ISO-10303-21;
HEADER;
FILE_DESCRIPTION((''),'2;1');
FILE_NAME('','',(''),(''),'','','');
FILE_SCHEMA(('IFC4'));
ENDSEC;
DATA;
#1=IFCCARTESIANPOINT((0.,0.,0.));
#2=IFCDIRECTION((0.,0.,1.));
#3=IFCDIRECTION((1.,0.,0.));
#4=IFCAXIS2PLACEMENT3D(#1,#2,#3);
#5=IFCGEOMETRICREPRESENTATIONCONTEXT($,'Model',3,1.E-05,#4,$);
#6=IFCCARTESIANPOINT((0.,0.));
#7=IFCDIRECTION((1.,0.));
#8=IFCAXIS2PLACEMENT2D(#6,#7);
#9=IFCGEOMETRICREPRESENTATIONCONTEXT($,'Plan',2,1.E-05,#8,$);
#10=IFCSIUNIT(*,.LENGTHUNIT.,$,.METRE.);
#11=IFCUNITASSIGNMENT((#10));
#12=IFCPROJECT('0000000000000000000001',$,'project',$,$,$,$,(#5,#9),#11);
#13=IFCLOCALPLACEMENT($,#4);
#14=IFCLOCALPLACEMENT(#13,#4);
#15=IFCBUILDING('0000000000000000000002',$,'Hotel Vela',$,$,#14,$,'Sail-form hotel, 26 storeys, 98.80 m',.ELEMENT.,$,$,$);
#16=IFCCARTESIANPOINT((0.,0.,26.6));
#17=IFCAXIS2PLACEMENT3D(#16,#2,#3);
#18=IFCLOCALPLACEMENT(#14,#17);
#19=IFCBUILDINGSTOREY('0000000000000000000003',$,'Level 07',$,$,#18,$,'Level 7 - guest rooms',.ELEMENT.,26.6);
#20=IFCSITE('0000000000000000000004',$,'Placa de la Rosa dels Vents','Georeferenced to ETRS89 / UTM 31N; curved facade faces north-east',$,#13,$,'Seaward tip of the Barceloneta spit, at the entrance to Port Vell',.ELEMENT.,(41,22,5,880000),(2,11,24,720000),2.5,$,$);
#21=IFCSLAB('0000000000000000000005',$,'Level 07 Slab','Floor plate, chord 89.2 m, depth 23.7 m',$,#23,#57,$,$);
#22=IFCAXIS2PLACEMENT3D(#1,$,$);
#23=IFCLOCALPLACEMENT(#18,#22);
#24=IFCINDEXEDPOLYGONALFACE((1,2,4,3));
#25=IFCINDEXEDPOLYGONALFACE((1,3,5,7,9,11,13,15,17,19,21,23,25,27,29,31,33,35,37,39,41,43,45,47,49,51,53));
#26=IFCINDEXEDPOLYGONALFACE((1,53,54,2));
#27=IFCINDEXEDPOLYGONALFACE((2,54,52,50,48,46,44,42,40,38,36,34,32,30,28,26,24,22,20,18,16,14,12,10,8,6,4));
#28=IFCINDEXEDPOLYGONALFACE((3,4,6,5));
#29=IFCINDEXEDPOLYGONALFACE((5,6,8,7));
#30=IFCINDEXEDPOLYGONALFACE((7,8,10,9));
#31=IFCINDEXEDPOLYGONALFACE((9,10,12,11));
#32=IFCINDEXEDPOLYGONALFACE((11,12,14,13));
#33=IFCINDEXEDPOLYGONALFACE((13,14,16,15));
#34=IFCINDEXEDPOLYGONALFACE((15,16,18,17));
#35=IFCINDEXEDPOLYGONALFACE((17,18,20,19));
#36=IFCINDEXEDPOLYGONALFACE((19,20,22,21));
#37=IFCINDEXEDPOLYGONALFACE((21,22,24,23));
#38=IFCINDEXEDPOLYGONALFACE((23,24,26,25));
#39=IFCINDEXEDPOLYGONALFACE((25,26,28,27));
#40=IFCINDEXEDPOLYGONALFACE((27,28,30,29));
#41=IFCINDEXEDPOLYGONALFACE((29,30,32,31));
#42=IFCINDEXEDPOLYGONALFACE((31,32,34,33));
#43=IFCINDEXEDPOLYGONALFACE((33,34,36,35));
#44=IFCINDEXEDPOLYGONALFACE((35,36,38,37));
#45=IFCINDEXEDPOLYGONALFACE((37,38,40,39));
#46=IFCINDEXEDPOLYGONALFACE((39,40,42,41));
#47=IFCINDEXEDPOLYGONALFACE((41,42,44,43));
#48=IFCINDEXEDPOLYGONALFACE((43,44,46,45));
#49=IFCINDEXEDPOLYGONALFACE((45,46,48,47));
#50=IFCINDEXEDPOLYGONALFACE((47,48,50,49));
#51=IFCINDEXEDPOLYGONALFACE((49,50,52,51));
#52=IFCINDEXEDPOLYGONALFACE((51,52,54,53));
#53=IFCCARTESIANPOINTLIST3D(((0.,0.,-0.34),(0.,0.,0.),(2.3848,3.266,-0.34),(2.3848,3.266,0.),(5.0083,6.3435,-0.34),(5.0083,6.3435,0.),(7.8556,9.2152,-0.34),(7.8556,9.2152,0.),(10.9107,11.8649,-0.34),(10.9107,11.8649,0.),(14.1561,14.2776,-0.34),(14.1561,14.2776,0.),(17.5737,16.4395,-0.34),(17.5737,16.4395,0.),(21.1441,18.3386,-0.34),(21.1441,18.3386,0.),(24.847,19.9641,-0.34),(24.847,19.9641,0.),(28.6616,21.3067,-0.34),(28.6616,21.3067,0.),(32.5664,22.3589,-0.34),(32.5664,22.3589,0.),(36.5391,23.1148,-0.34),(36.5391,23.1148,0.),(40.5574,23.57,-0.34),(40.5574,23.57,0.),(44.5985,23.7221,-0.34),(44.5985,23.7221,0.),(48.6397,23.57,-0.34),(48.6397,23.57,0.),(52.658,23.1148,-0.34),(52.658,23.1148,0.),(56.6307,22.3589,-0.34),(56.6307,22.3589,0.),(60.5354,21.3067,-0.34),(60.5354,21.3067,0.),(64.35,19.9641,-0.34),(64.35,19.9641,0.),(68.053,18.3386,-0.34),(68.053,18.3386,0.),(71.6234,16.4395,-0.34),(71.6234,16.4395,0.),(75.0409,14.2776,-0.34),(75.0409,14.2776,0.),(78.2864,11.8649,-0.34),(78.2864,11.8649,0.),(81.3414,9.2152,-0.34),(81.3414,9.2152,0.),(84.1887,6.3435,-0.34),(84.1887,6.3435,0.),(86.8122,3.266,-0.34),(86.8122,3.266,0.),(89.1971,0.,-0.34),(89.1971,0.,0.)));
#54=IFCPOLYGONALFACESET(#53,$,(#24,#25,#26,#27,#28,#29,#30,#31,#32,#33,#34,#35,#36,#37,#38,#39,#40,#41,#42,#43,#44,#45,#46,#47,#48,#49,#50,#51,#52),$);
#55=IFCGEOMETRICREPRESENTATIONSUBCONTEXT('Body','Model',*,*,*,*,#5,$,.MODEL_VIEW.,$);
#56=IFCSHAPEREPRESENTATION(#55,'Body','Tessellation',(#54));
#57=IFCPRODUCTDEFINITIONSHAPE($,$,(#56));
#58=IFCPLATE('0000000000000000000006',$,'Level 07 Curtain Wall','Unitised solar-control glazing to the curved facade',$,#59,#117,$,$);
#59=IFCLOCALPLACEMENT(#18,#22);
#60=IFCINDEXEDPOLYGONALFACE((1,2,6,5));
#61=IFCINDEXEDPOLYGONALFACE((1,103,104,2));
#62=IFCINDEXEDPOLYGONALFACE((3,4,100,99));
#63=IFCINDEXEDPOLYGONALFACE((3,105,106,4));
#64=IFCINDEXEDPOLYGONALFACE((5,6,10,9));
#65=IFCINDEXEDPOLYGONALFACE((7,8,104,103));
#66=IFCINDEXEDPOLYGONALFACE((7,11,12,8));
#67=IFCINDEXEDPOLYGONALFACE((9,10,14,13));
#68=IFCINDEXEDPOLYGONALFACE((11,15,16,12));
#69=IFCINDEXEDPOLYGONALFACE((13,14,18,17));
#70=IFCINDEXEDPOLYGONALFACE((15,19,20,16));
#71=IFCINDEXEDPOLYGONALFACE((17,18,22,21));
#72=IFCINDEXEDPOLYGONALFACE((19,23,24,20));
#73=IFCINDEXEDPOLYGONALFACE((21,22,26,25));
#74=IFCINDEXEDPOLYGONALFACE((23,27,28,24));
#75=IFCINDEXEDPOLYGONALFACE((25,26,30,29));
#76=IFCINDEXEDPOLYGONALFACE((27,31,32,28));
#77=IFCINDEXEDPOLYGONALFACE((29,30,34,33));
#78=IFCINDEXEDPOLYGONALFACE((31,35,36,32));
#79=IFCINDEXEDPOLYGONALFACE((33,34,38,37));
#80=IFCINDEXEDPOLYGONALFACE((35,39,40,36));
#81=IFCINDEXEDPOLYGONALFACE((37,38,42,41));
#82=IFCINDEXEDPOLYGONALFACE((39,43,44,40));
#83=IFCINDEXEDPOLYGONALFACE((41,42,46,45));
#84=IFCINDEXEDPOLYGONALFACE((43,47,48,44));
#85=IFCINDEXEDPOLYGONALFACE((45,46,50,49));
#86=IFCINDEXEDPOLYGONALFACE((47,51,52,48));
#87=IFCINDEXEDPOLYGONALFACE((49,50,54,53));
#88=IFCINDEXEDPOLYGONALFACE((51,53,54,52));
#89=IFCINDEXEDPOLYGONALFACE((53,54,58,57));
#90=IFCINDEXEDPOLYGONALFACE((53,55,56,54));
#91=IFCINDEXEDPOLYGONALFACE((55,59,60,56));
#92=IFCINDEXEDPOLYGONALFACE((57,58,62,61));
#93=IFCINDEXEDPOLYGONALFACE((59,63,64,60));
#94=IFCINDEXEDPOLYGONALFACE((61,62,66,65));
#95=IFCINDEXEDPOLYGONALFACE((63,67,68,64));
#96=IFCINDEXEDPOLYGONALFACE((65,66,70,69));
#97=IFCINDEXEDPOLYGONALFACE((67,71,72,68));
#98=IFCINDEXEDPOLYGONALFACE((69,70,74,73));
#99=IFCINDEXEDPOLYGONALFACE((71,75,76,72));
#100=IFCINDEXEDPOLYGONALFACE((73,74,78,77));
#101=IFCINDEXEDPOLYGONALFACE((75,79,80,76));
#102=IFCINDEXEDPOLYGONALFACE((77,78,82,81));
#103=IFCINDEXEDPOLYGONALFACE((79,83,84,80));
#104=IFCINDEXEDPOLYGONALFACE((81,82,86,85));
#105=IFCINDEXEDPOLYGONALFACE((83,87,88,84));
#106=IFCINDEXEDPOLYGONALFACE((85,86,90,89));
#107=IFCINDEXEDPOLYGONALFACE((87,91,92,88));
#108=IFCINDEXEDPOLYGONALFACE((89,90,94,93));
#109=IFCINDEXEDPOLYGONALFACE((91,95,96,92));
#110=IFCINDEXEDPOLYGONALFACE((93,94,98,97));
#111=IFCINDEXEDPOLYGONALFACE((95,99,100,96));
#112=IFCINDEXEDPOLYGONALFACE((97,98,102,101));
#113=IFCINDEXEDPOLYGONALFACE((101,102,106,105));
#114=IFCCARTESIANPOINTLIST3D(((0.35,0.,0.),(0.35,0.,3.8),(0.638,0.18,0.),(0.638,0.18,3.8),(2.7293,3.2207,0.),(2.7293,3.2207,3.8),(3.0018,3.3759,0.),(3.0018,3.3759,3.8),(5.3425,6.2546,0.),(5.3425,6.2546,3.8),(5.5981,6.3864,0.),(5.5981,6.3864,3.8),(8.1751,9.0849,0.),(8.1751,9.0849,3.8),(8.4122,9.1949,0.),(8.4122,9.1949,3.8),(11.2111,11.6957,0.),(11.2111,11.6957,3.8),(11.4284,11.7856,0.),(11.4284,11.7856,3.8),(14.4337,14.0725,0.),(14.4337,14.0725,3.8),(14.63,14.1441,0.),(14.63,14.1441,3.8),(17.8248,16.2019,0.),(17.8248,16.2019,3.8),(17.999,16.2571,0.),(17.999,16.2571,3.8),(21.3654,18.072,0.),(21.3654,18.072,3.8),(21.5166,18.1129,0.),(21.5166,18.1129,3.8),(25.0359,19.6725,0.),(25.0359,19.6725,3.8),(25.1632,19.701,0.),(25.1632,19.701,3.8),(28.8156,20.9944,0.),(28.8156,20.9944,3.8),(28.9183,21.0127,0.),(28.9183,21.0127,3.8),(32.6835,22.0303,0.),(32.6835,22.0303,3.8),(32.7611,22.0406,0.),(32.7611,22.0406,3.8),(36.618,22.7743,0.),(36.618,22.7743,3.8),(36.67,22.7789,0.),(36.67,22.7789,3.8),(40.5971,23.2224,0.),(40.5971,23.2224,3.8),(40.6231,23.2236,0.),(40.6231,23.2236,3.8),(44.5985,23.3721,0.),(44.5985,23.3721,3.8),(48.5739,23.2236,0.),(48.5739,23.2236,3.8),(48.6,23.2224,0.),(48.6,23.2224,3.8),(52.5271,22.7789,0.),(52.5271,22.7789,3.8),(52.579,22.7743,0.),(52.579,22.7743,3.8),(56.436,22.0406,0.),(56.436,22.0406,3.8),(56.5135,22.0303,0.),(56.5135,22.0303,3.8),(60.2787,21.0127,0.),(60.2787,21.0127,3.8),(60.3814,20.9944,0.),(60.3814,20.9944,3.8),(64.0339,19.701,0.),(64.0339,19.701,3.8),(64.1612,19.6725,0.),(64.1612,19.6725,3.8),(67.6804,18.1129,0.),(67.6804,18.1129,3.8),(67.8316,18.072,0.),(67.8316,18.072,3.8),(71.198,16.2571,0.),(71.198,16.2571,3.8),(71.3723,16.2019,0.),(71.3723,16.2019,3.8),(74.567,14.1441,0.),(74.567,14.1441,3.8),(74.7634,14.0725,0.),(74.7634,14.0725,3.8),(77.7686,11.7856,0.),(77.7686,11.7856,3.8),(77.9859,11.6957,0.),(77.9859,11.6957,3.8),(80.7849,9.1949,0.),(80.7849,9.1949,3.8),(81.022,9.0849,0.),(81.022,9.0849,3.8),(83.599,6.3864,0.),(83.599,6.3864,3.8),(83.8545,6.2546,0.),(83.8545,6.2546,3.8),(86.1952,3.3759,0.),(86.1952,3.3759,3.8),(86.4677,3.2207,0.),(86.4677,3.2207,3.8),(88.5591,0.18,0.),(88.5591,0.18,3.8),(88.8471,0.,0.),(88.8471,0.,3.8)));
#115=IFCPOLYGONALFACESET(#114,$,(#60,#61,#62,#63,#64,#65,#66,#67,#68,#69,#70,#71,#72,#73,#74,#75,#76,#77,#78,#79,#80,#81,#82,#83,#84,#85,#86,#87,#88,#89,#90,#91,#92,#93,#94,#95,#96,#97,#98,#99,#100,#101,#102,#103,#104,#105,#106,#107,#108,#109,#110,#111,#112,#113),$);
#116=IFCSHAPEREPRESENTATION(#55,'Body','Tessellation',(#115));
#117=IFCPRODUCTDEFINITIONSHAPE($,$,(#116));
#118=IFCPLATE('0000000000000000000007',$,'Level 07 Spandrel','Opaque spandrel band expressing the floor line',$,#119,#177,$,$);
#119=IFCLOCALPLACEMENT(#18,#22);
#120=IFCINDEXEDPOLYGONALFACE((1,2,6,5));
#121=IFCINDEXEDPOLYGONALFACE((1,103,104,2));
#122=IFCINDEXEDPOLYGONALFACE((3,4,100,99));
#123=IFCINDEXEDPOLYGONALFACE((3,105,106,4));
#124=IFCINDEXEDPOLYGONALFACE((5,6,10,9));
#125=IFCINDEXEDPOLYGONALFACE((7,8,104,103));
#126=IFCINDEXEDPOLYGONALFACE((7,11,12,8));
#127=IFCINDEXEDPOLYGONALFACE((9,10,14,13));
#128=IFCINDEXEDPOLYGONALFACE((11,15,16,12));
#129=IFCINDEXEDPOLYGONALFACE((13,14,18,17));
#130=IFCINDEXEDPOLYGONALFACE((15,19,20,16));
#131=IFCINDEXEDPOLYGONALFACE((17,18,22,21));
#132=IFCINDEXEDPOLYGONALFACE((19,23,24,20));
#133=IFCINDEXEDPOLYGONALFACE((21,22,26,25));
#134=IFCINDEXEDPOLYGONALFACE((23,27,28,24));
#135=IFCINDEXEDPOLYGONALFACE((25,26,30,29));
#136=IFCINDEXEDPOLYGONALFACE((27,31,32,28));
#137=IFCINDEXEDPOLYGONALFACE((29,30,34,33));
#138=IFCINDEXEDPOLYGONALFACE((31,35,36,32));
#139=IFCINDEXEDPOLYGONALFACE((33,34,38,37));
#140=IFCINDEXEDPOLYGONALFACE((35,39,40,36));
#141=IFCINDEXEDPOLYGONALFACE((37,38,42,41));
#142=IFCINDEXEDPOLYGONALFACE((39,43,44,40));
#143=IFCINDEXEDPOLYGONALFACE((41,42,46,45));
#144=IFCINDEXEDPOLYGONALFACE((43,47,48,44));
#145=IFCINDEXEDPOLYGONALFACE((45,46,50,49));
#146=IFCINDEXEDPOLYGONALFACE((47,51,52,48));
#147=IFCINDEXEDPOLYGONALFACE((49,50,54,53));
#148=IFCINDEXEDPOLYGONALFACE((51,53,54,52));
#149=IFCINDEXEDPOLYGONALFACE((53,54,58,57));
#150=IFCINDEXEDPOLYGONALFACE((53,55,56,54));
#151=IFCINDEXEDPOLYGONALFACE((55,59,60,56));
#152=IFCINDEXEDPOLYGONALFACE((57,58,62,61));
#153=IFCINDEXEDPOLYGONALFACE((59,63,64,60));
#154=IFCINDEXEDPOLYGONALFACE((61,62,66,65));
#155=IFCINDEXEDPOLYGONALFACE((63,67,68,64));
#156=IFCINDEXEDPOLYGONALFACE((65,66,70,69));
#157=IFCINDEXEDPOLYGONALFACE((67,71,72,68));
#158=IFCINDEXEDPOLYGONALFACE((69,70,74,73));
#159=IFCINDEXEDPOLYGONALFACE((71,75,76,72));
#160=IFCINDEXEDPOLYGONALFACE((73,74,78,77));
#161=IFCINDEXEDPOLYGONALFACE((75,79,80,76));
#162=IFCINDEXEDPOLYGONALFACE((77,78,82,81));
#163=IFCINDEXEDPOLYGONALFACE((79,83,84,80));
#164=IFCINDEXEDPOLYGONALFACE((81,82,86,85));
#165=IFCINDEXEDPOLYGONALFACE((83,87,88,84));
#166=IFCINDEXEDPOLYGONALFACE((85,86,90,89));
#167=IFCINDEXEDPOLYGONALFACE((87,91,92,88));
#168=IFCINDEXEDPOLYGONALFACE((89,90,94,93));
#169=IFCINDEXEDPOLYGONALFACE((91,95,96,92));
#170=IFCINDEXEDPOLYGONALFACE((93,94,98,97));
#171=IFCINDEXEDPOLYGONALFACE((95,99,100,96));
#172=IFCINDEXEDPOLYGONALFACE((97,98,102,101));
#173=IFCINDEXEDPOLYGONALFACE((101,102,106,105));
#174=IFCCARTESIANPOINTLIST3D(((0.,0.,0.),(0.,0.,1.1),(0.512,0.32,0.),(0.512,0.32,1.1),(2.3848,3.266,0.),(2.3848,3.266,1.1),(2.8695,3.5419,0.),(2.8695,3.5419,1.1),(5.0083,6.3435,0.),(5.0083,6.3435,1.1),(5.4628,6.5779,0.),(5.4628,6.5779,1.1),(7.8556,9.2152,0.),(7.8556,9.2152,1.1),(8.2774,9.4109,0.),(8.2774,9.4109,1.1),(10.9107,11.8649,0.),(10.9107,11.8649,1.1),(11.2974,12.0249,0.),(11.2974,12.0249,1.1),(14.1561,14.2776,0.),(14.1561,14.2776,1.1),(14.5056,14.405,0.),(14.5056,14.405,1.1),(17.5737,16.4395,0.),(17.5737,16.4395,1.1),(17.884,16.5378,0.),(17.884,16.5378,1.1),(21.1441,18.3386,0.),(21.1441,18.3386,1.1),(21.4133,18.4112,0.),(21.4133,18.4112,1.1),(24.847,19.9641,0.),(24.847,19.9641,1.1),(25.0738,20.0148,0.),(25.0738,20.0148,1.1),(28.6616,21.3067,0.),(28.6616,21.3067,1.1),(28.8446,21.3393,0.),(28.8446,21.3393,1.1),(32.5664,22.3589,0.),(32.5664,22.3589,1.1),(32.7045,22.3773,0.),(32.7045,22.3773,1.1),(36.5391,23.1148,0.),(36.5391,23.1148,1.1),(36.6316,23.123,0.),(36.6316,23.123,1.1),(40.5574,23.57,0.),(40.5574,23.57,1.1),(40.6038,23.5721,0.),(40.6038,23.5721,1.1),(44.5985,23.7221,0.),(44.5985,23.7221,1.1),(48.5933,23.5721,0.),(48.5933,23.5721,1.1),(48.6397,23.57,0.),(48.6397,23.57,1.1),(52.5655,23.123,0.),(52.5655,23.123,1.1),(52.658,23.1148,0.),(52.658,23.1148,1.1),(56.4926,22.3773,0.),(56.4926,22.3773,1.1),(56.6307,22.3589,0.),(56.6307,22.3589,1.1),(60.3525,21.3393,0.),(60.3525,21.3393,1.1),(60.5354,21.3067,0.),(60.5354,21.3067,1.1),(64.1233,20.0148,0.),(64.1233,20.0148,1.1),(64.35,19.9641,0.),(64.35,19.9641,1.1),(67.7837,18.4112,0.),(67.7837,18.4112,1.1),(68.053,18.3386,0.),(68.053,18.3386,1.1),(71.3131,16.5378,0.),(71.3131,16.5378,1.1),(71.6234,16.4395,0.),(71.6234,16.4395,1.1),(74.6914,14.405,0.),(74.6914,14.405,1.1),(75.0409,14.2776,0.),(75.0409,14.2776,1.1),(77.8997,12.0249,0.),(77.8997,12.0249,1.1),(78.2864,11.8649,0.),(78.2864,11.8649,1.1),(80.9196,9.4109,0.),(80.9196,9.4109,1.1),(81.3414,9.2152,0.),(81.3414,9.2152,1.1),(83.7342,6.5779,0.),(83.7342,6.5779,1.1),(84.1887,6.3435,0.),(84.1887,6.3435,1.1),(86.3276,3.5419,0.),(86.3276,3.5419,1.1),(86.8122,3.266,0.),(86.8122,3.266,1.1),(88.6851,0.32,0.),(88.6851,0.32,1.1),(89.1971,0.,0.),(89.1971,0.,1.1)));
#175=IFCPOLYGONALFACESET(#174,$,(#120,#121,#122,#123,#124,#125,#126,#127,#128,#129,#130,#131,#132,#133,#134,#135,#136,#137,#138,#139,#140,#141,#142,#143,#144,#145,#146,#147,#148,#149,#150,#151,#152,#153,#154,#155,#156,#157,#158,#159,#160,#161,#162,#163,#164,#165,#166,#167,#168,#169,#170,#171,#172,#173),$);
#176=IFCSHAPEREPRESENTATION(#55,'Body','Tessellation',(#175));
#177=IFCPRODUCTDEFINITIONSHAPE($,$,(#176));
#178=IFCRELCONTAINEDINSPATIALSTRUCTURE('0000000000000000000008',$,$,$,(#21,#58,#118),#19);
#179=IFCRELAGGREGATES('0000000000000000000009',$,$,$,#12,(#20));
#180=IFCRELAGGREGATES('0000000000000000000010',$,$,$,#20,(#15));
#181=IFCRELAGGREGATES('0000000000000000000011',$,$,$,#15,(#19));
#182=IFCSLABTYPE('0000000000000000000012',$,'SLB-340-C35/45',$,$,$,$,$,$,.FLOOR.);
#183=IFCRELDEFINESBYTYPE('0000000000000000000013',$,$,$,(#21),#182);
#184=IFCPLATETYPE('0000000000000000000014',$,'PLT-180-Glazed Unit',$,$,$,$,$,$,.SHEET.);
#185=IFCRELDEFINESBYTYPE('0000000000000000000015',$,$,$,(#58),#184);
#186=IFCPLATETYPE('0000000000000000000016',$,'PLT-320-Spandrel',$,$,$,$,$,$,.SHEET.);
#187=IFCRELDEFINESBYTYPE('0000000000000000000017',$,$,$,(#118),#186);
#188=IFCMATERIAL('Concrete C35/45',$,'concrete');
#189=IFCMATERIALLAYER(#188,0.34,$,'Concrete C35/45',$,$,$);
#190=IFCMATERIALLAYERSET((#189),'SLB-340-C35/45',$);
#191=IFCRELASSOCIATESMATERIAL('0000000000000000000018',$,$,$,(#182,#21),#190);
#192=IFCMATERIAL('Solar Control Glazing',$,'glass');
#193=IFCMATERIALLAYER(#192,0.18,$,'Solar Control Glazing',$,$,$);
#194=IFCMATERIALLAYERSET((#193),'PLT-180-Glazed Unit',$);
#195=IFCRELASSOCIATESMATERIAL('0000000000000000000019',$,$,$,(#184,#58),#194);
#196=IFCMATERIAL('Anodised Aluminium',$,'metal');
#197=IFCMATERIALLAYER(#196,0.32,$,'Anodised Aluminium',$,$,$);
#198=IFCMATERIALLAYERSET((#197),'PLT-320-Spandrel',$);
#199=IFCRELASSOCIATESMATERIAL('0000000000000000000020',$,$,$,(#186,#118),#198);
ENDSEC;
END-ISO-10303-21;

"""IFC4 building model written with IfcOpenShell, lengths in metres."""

from ifc_helpers import new_model, si_unit, frame, origin_with_axes, origin_2d_with_axis, place, context, subcontext, project, spatial, line, indexed_curve, outline, extrude, material, layer, layer_set, layer_usage, type_object, element, save


model = new_model("IFC4")

# Units and contexts
model_context = context("Model", 3, precision=1e-05, world=origin_with_axes())
plan_context = context("Plan", 2, precision=1e-05, world=origin_2d_with_axis())
body_context = subcontext(model_context, "Body", "Model", "MODEL_VIEW")
ifc_project = project(units=[si_unit("LENGTHUNIT", "METRE")], contexts=[model_context, plan_context])

# Site, building, storey
site_placement = place(None, origin_with_axes())
site = spatial("IfcSite", under=ifc_project, at=site_placement, Name="Placa de la Rosa dels Vents", Description="Georeferenced to ETRS89 / UTM 31N; curved facade faces north-east", LongName="Seaward tip of the Barceloneta spit, at the entrance to Port Vell", CompositionType="ELEMENT", RefLatitude=(41, 22, 5, 880000), RefLongitude=(2, 11, 24, 720000), RefElevation=2.5)
building_placement = place(site_placement, origin_with_axes())
building = spatial("IfcBuilding", under=site, at=building_placement, Name="Hotel Vela", LongName="Sail-form hotel, 26 storeys, 98.80 m", CompositionType="ELEMENT")
storey_placement = place(building_placement, frame((0.0, 0.0, 26.6), z_axis=(0.0, 0.0, 1.0), x_axis=(1.0, 0.0, 0.0)))
storey = spatial("IfcBuildingStorey", under=building, at=storey_placement, Name="Level 07", LongName="Level 7 - guest rooms", CompositionType="ELEMENT", Elevation=26.6)

# Slab
ifc_material_1 = material(Name="Concrete C35/45", Category="concrete")
ifc_layer_1 = layer(ifc_material_1, 0.34, Name="Concrete C35/45")
ifc_layer_set_1 = layer_set([ifc_layer_1], Name="SLB-340-C35/45")
ifc_layer_usage_1 = layer_usage(ifc_layer_set_1, "AXIS3", "POSITIVE", 0.0)
slab_type = type_object("IfcSlabType", Name="SLB-340-C35/45", PredefinedType="FLOOR", material=ifc_layer_set_1)
slab_placement = place(storey_placement, frame((0.0, 0.0, -0.34), z_axis=(0.0, 0.0, 1.0), x_axis=(1.0, 0.0, 0.0)))
element("IfcSlab", 1, at=slab_placement, inside=storey, type_object=slab_type, material=ifc_layer_usage_1, Name="Level 07 Slab", Description="Floor plate, chord 89.2 m, depth 23.7 m", context=body_context, shape_type="SweptSolid", body=[
    extrude(outline(indexed_curve([(0.0, 0.0), (89.1971, 0.0), (86.8122, 3.266), (84.1887, 6.3435), (81.3414, 9.2152), (78.2864, 11.8649), (75.0409, 14.2776), (71.6234, 16.4395), (68.053, 18.3386), (64.35, 19.9641), (60.5354, 21.3067), (56.6307, 22.3589), (52.658, 23.1148), (48.6397, 23.57), (44.5985, 23.7221), (40.5574, 23.57), (36.5391, 23.1148), (32.5664, 22.3589), (28.6616, 21.3067), (24.847, 19.9641), (21.1441, 18.3386), (17.5737, 16.4395), (14.1561, 14.2776), (10.9107, 11.8649), (7.8556, 9.2152), (5.0083, 6.3435), (2.3848, 3.266)], segments=[line(1, 2, 3, 4, 5, 6, 7, 8, 9, 10, 11, 12, 13, 14, 15, 16, 17, 18, 19, 20, 21, 22, 23, 24, 25, 26, 27, 1)])), origin_with_axes(), (0.0, 0.0, 1.0), 0.34),
])

# Plates
ifc_material_2 = material(Name="Solar Control Glazing", Category="glass")
ifc_layer_2 = layer(ifc_material_2, 0.18, Name="Solar Control Glazing")
ifc_layer_set_2 = layer_set([ifc_layer_2], Name="PLT-180-Glazed Unit")
ifc_layer_usage_2 = layer_usage(ifc_layer_set_2, "AXIS2", "POSITIVE", 0.0)
plate_type_1 = type_object("IfcPlateType", Name="PLT-180-Glazed Unit", PredefinedType="SHEET", material=ifc_layer_set_2)
plate_1_placement = place(storey_placement, frame((0.35, 0.0, 0.0), z_axis=(0.0, 0.0, 1.0), x_axis=(1.0, 0.0, 0.0)))
element("IfcPlate", 2, at=plate_1_placement, inside=storey, type_object=plate_type_1, material=ifc_layer_usage_2, Name="Level 07 Curtain Wall", Description="Unitised solar-control glazing to the curved facade", context=body_context, shape_type="SweptSolid", body=[
    extrude(outline(indexed_curve([(88.4971, 0.0), (86.1177, 3.2207), (83.5045, 6.2546), (80.672, 9.0849), (77.6359, 11.6957), (74.4134, 14.0725), (71.0223, 16.2019), (67.4816, 18.072), (63.8112, 19.6725), (60.0314, 20.9944), (56.1635, 22.0303), (52.229, 22.7743), (48.25, 23.2224), (44.2485, 23.3721), (40.2471, 23.2224), (36.268, 22.7743), (32.3335, 22.0303), (28.4656, 20.9944), (24.6859, 19.6725), (21.0154, 18.072), (17.4748, 16.2019), (14.0837, 14.0725), (10.8611, 11.6957), (7.8251, 9.0849), (4.9925, 6.2546), (2.3793, 3.2207), (0.0, 0.0), (88.2091, 0.18), (2.6518, 3.3759), (5.2481, 6.3864), (8.0622, 9.1949), (11.0784, 11.7856), (14.28, 14.1441), (17.649, 16.2571), (21.1666, 18.1129), (24.8132, 19.701), (28.5683, 21.0127), (32.4111, 22.0406), (36.32, 22.7789), (40.2731, 23.2236), (44.2485, 23.3721), (48.2239, 23.2236), (52.1771, 22.7789), (56.086, 22.0406), (59.9287, 21.0127), (63.6839, 19.701), (67.3304, 18.1129), (70.848, 16.2571), (74.217, 14.1441), (77.4186, 11.7856), (80.4349, 9.1949), (83.249, 6.3864), (85.8452, 3.3759), (0.288, 0.18)], segments=[line(1, 2, 3, 4, 5, 6, 7, 8, 9, 10, 11, 12, 13, 14, 15, 16, 17, 18, 19, 20, 21, 22, 23, 24, 25, 26, 27, 28, 29, 30, 31, 32, 33, 34, 35, 36, 37, 38, 39, 40, 41, 42, 43, 44, 45, 46, 47, 48, 49, 50, 51, 52, 53, 54, 1)])), origin_with_axes(), (0.0, 0.0, 1.0), 3.8),
])
ifc_material_3 = material(Name="Anodised Aluminium", Category="metal")
ifc_layer_3 = layer(ifc_material_3, 0.32, Name="Anodised Aluminium")
ifc_layer_set_3 = layer_set([ifc_layer_3], Name="PLT-320-Spandrel")
ifc_layer_usage_3 = layer_usage(ifc_layer_set_3, "AXIS2", "POSITIVE", 0.0)
plate_type_2 = type_object("IfcPlateType", Name="PLT-320-Spandrel", PredefinedType="SHEET", material=ifc_layer_set_3)
plate_2_placement = place(storey_placement, origin_with_axes())
element("IfcPlate", 3, at=plate_2_placement, inside=storey, type_object=plate_type_2, material=ifc_layer_usage_3, Name="Level 07 Spandrel", Description="Opaque spandrel band expressing the floor line", context=body_context, shape_type="SweptSolid", body=[
    extrude(outline(indexed_curve([(89.1971, 0.0), (86.8122, 3.266), (84.1887, 6.3435), (81.3414, 9.2152), (78.2864, 11.8649), (75.0409, 14.2776), (71.6234, 16.4395), (68.053, 18.3386), (64.35, 19.9641), (60.5354, 21.3067), (56.6307, 22.3589), (52.658, 23.1148), (48.6397, 23.57), (44.5985, 23.7221), (40.5574, 23.57), (36.5391, 23.1148), (32.5664, 22.3589), (28.6616, 21.3067), (24.847, 19.9641), (21.1441, 18.3386), (17.5737, 16.4395), (14.1561, 14.2776), (10.9107, 11.8649), (7.8556, 9.2152), (5.0083, 6.3435), (2.3848, 3.266), (0.0, 0.0), (88.6851, 0.32), (2.8695, 3.5419), (5.4628, 6.5779), (8.2774, 9.4109), (11.2974, 12.0249), (14.5056, 14.405), (17.884, 16.5378), (21.4133, 18.4112), (25.0738, 20.0148), (28.8446, 21.3393), (32.7045, 22.3773), (36.6316, 23.123), (40.6038, 23.5721), (44.5985, 23.7221), (48.5933, 23.5721), (52.5655, 23.123), (56.4926, 22.3773), (60.3525, 21.3393), (64.1233, 20.0148), (67.7837, 18.4112), (71.3131, 16.5378), (74.6914, 14.405), (77.8997, 12.0249), (80.9196, 9.4109), (83.7342, 6.5779), (86.3276, 3.5419), (0.512, 0.32)], segments=[line(1, 2, 3, 4, 5, 6, 7, 8, 9, 10, 11, 12, 13, 14, 15, 16, 17, 18, 19, 20, 21, 22, 23, 24, 25, 26, 27, 28, 29, 30, 31, 32, 33, 34, 35, 36, 37, 38, 39, 40, 41, 42, 43, 44, 45, 46, 47, 48, 49, 50, 51, 52, 53, 54, 1)])), origin_with_axes(), (0.0, 0.0, 1.0), 1.1),
])

save(model, "model.ifc")
